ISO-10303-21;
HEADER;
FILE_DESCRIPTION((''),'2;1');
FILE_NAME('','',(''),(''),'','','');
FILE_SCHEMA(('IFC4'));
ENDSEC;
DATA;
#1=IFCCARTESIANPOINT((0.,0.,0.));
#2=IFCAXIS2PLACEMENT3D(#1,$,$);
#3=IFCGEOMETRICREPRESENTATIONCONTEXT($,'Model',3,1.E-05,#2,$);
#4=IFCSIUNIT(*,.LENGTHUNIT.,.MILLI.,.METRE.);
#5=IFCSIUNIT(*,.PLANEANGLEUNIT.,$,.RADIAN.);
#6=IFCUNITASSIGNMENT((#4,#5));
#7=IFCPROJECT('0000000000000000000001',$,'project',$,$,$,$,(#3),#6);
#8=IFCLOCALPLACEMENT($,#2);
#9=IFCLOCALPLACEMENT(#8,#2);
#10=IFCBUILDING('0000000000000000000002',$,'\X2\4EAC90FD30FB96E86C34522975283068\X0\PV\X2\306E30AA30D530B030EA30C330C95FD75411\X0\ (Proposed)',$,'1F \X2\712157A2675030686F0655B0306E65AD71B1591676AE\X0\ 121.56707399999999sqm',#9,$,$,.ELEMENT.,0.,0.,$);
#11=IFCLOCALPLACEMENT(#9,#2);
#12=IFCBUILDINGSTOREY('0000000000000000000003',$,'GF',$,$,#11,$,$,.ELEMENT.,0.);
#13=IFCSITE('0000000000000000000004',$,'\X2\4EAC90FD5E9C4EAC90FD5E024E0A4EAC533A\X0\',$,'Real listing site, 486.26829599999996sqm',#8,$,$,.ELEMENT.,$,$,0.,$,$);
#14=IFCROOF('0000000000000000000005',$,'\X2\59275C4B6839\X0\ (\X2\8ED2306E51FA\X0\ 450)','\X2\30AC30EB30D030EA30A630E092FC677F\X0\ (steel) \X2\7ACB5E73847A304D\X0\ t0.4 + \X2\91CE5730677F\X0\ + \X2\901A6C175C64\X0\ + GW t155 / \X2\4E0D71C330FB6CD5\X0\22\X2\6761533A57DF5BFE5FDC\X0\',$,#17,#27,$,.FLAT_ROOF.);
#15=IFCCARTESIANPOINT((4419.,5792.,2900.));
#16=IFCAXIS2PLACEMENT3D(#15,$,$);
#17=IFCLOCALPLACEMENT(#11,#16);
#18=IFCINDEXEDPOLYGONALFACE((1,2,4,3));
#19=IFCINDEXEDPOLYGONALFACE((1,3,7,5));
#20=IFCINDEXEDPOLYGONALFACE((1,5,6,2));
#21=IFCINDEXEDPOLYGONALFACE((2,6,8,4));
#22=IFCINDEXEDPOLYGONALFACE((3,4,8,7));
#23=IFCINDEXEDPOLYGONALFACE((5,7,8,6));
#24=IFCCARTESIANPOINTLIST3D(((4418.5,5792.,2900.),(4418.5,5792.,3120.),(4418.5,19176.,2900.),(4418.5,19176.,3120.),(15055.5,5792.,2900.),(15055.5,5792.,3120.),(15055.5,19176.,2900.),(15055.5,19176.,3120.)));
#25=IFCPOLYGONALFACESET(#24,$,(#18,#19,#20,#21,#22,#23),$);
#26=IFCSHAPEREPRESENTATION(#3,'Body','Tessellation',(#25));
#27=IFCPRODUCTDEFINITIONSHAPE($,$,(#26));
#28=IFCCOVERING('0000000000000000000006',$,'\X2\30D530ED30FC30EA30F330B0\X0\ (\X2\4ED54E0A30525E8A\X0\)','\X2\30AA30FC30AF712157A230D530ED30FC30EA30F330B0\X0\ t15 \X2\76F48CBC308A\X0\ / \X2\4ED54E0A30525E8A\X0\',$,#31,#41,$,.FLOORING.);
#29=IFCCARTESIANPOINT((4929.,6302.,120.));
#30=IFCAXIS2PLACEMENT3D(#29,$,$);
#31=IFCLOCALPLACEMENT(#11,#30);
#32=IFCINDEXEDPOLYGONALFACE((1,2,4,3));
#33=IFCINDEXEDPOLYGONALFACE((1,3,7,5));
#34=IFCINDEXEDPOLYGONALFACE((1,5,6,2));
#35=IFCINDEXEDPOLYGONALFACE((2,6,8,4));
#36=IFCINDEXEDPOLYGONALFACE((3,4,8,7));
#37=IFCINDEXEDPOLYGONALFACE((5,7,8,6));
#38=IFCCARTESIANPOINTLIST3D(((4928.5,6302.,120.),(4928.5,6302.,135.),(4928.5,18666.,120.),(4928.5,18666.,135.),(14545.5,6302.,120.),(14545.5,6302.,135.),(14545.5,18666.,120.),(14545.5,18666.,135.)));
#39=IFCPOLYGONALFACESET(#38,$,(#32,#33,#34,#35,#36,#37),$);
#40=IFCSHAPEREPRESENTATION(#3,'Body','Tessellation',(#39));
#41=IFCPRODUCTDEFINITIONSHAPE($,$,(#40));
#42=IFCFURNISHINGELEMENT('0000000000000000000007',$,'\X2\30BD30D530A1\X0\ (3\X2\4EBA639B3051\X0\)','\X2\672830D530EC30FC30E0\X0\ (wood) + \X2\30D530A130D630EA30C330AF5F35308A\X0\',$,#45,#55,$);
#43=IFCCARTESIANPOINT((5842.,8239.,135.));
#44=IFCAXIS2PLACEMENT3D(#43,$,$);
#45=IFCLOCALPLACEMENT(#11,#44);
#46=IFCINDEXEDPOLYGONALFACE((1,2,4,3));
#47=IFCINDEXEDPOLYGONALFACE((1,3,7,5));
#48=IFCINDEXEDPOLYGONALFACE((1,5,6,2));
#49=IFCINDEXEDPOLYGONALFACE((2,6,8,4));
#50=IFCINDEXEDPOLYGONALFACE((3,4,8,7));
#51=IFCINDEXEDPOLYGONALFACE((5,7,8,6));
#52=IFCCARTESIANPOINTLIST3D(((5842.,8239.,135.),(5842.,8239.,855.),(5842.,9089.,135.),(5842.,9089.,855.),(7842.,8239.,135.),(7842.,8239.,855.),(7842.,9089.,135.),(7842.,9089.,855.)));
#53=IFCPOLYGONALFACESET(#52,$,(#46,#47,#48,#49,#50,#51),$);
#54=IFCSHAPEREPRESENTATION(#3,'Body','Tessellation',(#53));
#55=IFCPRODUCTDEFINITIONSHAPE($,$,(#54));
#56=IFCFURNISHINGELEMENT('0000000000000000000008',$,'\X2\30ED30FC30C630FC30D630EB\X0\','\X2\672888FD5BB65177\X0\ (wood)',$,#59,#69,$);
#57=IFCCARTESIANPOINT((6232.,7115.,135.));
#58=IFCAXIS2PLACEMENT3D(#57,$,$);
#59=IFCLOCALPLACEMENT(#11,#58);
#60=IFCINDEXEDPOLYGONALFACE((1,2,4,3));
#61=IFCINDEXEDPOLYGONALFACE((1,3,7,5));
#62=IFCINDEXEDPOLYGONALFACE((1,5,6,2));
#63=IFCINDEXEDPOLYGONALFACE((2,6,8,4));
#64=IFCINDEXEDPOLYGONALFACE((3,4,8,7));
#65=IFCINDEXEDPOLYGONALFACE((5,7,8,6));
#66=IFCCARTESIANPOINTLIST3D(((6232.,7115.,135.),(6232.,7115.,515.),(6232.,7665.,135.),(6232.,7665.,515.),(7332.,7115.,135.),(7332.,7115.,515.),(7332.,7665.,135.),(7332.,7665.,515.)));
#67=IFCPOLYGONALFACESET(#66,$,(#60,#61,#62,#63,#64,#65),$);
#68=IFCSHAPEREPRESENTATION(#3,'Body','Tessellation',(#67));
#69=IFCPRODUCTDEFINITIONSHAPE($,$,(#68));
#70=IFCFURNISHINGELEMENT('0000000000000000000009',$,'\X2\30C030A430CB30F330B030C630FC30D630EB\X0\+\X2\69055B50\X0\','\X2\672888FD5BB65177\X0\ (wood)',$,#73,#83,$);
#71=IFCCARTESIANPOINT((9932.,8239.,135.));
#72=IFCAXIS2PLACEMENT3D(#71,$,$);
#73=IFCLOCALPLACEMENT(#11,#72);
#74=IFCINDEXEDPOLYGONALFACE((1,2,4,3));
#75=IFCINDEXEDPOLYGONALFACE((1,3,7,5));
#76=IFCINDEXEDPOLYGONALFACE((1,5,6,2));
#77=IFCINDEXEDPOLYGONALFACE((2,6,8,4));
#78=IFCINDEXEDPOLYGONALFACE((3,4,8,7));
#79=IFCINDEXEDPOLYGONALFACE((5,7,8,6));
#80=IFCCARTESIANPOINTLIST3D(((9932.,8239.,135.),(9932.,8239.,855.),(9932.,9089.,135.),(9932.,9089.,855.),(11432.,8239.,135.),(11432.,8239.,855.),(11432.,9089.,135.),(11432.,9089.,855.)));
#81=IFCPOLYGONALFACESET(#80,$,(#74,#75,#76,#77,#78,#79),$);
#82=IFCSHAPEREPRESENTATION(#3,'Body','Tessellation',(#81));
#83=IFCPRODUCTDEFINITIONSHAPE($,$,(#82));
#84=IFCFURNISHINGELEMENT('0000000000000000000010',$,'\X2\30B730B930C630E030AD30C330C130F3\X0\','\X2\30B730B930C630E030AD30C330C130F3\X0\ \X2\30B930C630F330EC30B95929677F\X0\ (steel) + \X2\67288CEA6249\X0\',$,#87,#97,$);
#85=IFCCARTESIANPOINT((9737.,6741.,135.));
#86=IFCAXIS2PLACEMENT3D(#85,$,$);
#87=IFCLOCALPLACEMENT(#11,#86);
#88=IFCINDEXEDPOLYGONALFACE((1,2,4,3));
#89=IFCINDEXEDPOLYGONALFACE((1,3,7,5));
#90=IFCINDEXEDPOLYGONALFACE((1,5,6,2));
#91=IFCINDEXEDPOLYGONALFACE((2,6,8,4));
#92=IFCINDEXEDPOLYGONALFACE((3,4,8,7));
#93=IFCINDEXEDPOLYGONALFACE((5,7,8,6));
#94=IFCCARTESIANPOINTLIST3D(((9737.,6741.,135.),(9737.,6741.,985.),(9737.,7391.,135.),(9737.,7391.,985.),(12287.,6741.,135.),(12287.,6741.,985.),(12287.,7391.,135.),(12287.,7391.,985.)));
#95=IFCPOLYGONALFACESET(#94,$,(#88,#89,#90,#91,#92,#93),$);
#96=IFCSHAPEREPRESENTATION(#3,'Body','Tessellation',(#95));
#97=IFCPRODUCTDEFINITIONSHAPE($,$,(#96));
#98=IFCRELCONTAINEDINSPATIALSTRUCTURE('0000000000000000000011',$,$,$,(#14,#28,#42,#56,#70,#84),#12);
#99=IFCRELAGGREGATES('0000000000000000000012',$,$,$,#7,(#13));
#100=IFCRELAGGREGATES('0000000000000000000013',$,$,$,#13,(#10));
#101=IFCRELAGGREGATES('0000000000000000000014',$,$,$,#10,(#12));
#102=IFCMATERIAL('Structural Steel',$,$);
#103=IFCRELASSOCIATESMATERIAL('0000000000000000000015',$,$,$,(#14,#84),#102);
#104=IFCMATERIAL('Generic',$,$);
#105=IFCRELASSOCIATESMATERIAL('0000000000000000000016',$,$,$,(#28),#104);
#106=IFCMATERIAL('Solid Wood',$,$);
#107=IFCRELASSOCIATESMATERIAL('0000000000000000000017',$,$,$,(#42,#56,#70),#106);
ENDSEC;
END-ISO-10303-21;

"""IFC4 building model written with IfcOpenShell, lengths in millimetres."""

from ifc_helpers import new_model, si_unit, frame, frame_2d, origin, place, context, project, spatial, rectangle, extrude, material, element, save


model = new_model("IFC4")

# Units and contexts
model_context = context("Model", 3, precision=1e-05, world=origin())
ifc_project = project(units=[si_unit("LENGTHUNIT", "METRE", prefix="MILLI"), si_unit("PLANEANGLEUNIT", "RADIAN")], contexts=[model_context])

# Site, building, storey
site_placement = place(None, origin())
site = spatial("IfcSite", under=ifc_project, at=site_placement, Name="京都府京都市上京区", ObjectType="Real listing site, 486.26829599999996sqm", CompositionType="ELEMENT", RefElevation=0.0)
building_placement = place(site_placement, origin())
building = spatial("IfcBuilding", under=site, at=building_placement, Name="京都・雨水利用とPVのオフグリッド志向 (Proposed)", ObjectType="1F 無垢材と漆喰の断熱外皮 121.56707399999999sqm", CompositionType="ELEMENT", ElevationOfRefHeight=0.0, ElevationOfTerrain=0.0)
storey_placement = place(building_placement, origin())
storey = spatial("IfcBuildingStorey", under=building, at=storey_placement, Name="GF", CompositionType="ELEMENT", Elevation=0.0)

# Shared definitions
ifc_material_1 = material(Name="Solid Wood")

# Roof
ifc_material_2 = material(Name="Structural Steel")
roof_placement = place(storey_placement, frame((4419.0, 5792.0, 2900.0)))
element("IfcRoof", 1, at=roof_placement, inside=storey, material=ifc_material_2, Name="大屋根 (軒の出 450)", Description="ガルバリウム鋼板 (steel) 立平葺き t0.4 + 野地板 + 通気層 + GW t155 / 不燃・法22条区域対応", PredefinedType="FLAT_ROOF", context=model_context, shape_type="SweptSolid", body=[
    extrude(rectangle(XDim=10637.0, YDim=13384.0, at=frame_2d((5318.0, 6692.0))), frame((4419.0, 5792.0, 2900.0)), (0.0, 0.0, 1.0), 220.0),
])

# Covering
ifc_material_3 = material(Name="Generic")
covering_placement = place(storey_placement, frame((4929.0, 6302.0, 120.0)))
element("IfcCovering", 2, at=covering_placement, inside=storey, material=ifc_material_3, Name="フローリング (仕上げ床)", Description="オーク無垢フローリング t15 直貼り / 仕上げ床", PredefinedType="FLOORING", context=model_context, shape_type="SweptSolid", body=[
    extrude(rectangle(XDim=9617.0, YDim=12364.0, at=frame_2d((4808.0, 6182.0))), frame((4929.0, 6302.0, 120.0)), (0.0, 0.0, 1.0), 15.0),
])

# Furnishing elements
furnishing_1_placement = place(storey_placement, frame((5842.0, 8239.0, 135.0)))
element("IfcFurnishingElement", 3, at=furnishing_1_placement, inside=storey, material=ifc_material_1, Name="ソファ (3人掛け)", Description="木フレーム (wood) + ファブリック張り", context=model_context, shape_type="SweptSolid", body=[
    extrude(rectangle(XDim=2000.0, YDim=850.0, at=frame_2d((1000.0, 425.0))), frame((5842.0, 8239.0, 135.0)), (0.0, 0.0, 1.0), 720.0),
])
furnishing_2_placement = place(storey_placement, frame((6232.0, 7115.0, 135.0)))
element("IfcFurnishingElement", 4, at=furnishing_2_placement, inside=storey, material=ifc_material_1, Name="ローテーブル", Description="木製家具 (wood)", context=model_context, shape_type="SweptSolid", body=[
    extrude(rectangle(XDim=1100.0, YDim=550.0, at=frame_2d((550.0, 275.0))), frame((6232.0, 7115.0, 135.0)), (0.0, 0.0, 1.0), 380.0),
])
furnishing_3_placement = place(storey_placement, frame((9932.0, 8239.0, 135.0)))
element("IfcFurnishingElement", 5, at=furnishing_3_placement, inside=storey, material=ifc_material_1, Name="ダイニングテーブル+椅子", Description="木製家具 (wood)", context=model_context, shape_type="SweptSolid", body=[
    extrude(rectangle(XDim=1500.0, YDim=850.0, at=frame_2d((750.0, 425.0))), frame((9932.0, 8239.0, 135.0)), (0.0, 0.0, 1.0), 720.0),
])
furnishing_4_placement = place(storey_placement, frame((9737.0, 6741.0, 135.0)))
element("IfcFurnishingElement", 6, at=furnishing_4_placement, inside=storey, material=ifc_material_2, Name="システムキッチン", Description="システムキッチン ステンレス天板 (steel) + 木質扉", context=model_context, shape_type="SweptSolid", body=[
    extrude(rectangle(XDim=2550.0, YDim=650.0, at=frame_2d((1275.0, 325.0))), frame((9737.0, 6741.0, 135.0)), (0.0, 0.0, 1.0), 850.0),
])

save(model, "model.ifc")
